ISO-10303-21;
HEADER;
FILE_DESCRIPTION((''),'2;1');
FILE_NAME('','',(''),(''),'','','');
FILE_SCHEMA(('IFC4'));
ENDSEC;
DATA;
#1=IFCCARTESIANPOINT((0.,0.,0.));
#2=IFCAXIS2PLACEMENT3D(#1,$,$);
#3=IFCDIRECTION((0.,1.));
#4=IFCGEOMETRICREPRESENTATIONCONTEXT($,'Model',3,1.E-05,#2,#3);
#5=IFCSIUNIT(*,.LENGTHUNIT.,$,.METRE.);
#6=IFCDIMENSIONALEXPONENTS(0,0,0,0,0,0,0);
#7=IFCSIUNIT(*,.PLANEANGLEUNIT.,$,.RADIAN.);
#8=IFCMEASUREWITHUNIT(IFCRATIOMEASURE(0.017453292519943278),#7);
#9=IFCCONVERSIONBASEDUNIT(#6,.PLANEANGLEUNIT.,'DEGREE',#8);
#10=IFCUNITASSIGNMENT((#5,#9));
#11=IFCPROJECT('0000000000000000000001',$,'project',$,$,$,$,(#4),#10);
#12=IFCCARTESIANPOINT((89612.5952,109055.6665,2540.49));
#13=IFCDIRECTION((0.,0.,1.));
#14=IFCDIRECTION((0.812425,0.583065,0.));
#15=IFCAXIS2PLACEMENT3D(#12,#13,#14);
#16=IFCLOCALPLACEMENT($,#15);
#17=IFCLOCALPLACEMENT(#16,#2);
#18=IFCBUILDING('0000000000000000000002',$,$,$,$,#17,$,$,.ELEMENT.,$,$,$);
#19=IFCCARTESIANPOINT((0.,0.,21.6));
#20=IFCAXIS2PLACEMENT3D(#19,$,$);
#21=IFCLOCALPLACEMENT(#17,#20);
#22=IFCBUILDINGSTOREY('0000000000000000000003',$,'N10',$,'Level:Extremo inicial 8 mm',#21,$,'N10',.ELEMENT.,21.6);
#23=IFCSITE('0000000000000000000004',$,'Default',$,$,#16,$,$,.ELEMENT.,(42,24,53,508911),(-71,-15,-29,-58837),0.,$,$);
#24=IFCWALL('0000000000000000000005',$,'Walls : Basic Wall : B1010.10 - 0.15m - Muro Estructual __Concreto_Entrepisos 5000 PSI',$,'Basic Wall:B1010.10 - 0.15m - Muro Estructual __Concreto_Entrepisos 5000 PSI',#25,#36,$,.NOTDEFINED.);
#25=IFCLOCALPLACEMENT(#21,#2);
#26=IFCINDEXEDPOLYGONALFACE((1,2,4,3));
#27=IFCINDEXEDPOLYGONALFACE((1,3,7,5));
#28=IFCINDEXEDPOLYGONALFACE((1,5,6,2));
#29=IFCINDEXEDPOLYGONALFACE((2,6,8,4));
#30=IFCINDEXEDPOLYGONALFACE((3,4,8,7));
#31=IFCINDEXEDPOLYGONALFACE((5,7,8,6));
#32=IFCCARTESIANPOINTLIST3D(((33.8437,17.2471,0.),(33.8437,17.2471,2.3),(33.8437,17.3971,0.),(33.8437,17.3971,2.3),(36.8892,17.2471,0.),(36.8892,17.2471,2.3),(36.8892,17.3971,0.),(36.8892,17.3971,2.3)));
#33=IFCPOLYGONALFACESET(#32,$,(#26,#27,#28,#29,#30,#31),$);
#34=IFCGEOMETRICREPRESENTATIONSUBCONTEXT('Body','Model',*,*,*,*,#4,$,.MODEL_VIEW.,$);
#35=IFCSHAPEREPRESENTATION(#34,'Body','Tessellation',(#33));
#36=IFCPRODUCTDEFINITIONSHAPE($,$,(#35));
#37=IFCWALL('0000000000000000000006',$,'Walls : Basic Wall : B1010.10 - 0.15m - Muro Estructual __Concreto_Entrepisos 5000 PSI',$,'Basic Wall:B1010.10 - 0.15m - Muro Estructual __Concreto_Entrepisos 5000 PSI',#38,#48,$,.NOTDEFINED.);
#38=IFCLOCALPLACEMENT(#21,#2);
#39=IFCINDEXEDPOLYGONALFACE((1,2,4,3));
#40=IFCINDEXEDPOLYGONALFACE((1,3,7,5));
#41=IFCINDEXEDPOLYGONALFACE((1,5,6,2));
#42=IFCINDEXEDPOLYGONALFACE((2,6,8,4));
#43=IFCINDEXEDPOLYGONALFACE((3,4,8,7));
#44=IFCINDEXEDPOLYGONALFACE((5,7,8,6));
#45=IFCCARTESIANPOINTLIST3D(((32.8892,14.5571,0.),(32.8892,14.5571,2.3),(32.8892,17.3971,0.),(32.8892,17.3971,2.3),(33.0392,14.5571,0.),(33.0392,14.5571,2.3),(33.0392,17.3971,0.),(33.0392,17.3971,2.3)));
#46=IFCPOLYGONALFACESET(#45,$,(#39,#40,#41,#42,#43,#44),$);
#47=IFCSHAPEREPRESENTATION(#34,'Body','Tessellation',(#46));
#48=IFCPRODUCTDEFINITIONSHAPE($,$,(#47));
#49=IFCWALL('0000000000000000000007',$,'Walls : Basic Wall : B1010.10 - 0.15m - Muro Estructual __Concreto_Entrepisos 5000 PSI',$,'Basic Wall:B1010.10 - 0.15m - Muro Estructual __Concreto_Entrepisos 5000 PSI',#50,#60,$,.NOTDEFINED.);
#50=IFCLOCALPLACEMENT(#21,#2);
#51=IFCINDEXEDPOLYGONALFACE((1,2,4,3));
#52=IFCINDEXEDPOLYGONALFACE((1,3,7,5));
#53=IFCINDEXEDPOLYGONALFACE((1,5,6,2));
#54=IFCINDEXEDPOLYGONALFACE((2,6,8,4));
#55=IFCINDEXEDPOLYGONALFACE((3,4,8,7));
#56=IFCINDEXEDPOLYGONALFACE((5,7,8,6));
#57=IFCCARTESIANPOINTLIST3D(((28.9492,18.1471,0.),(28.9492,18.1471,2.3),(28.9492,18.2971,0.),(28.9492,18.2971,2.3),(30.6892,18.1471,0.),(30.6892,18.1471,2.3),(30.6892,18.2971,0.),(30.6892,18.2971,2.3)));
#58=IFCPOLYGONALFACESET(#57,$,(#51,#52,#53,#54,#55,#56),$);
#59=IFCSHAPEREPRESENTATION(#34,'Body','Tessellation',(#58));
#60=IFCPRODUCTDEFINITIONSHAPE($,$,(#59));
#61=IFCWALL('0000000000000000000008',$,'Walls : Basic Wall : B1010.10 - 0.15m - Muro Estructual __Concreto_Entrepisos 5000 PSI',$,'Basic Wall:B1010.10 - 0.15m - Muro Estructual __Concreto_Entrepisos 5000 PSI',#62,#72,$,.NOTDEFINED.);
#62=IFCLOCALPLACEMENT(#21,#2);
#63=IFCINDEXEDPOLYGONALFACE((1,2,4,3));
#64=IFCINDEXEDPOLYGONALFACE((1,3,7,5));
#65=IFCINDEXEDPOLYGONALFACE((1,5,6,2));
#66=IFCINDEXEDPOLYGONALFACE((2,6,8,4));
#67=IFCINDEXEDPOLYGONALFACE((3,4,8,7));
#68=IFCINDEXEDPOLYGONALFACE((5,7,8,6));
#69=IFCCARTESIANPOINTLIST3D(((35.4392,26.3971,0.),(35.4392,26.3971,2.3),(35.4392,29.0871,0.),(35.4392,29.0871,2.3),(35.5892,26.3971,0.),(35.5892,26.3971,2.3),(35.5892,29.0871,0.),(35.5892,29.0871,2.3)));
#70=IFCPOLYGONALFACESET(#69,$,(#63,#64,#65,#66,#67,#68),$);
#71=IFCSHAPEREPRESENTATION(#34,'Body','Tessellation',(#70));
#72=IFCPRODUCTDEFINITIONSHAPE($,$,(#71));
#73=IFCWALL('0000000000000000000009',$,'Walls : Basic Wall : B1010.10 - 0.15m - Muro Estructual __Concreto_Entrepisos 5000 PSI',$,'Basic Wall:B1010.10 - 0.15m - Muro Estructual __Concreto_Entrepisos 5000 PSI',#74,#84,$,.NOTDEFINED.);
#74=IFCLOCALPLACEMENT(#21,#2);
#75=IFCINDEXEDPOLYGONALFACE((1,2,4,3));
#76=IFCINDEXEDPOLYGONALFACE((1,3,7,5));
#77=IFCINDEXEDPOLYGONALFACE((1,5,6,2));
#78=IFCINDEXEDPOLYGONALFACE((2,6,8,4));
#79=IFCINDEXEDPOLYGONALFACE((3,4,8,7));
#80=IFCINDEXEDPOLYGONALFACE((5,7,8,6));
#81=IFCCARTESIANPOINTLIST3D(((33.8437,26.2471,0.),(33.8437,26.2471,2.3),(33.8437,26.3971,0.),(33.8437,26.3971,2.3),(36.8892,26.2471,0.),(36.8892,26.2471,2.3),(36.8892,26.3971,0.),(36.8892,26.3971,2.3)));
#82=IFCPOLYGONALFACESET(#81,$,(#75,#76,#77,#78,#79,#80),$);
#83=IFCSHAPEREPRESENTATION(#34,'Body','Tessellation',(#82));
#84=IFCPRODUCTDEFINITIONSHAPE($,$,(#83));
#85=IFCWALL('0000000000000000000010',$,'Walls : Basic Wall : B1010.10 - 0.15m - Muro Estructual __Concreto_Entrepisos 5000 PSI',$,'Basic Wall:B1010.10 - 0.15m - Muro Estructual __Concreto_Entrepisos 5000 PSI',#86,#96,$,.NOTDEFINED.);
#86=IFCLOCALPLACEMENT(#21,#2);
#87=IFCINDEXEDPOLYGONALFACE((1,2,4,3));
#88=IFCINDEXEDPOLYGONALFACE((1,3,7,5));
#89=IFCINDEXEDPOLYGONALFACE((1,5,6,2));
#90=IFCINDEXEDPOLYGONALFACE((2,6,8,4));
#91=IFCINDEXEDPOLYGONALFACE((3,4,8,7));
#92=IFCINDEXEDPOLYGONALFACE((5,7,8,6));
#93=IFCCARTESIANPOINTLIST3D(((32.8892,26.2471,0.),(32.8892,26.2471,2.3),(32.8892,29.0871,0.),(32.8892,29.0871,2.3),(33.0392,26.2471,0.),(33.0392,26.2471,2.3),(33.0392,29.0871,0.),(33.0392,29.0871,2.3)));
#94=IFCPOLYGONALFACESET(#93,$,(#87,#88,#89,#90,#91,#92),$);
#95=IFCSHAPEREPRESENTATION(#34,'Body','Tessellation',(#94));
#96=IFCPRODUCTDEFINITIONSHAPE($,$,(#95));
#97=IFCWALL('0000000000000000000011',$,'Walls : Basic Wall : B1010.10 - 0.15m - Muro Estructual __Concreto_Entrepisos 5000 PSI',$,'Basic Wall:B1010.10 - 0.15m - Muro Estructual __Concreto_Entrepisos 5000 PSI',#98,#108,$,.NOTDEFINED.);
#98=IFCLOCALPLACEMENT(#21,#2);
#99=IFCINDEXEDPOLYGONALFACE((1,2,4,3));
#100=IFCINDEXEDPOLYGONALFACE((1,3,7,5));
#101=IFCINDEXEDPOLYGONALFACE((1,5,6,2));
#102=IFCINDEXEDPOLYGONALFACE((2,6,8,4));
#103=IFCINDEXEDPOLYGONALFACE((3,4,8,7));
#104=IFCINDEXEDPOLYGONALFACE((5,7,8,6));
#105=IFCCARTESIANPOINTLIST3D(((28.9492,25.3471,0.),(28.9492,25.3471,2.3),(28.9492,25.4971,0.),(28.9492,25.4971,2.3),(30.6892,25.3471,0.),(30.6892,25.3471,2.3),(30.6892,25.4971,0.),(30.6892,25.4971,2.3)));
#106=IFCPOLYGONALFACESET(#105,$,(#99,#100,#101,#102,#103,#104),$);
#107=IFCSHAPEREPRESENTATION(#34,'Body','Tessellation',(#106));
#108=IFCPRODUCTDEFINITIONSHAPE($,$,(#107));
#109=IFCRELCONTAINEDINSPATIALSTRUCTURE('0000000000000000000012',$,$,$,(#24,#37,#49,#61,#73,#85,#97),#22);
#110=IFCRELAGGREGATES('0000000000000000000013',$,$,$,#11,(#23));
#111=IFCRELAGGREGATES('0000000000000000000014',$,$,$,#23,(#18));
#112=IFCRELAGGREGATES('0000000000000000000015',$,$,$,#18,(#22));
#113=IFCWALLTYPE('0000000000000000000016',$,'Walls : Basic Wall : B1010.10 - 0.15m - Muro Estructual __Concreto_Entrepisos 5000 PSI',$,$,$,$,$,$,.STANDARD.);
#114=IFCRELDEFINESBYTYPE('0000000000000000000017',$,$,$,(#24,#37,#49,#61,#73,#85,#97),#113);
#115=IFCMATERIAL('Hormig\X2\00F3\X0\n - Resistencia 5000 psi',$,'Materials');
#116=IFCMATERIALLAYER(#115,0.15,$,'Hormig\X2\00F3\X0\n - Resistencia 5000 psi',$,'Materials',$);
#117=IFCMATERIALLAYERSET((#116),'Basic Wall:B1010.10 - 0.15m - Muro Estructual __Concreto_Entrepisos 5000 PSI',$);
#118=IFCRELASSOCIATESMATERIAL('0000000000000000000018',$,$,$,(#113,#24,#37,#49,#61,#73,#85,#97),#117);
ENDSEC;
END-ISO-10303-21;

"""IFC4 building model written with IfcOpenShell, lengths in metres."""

from ifc_helpers import new_model, entity, si_unit, converted_unit, direction, frame, frame_2d, origin, place, context, subcontext, project, spatial, rectangle, extrude, material, layer, layer_set, layer_usage, type_object, element, save


model = new_model("IFC4")

# Units and contexts
model_context = context("Model", 3, precision=1e-05, world=origin(), true_north=direction((0.0, 1.0)))
body_context = subcontext(model_context, "Body", "Model", "MODEL_VIEW")
ifc_project = project(units=[si_unit("LENGTHUNIT", "METRE"), converted_unit("PLANEANGLEUNIT", "DEGREE", entity("IfcRatioMeasure", 0.017453292519943278), si_unit("PLANEANGLEUNIT", "RADIAN"), dimensions=[0, 0, 0, 0, 0, 0, 0])], contexts=[model_context])

# Site, building, storey
site_placement = place(None, frame((89612.5952, 109055.6665, 2540.49), z_axis=(0.0, 0.0, 1.0), x_axis=(0.812425, 0.583065, 0.0)))
site = spatial("IfcSite", under=ifc_project, at=site_placement, Name="Default", CompositionType="ELEMENT", RefLatitude=(42, 24, 53, 508911), RefLongitude=(-71, -15, -29, -58837), RefElevation=0.0)
building_placement = place(site_placement, origin())
building = spatial("IfcBuilding", under=site, at=building_placement, CompositionType="ELEMENT")
storey_placement = place(building_placement, frame((0.0, 0.0, 21.6)))
storey = spatial("IfcBuildingStorey", under=building, at=storey_placement, Name="N10", ObjectType="Level:Extremo inicial 8 mm", LongName="N10", CompositionType="ELEMENT", Elevation=21.6)

# Walls
ifc_material = material(Name="Hormigón - Resistencia 5000 psi", Category="Materials")
ifc_layer_1 = layer(ifc_material, 0.15, Name="Hormigón - Resistencia 5000 psi", Category="Materials")
ifc_layer_set_1 = layer_set([ifc_layer_1], Name="Basic Wall:B1010.10 - 0.15m - Muro Estructual __Concreto_Entrepisos 5000 PSI")
wall_type_1 = type_object("IfcWallType", Name="Walls : Basic Wall : B1010.10 - 0.15m - Muro Estructual __Concreto_Entrepisos 5000 PSI", PredefinedType="STANDARD", material=ifc_layer_set_1)
ifc_layer_usage_1 = layer_usage(ifc_layer_set_1, "AXIS2", "NEGATIVE", 0.075)
wall_1_placement = place(storey_placement, frame((36.8892, 17.3221, 0.0), z_axis=(0.0, 0.0, 1.0), x_axis=(-1.0, 0.0, 0.0)))
element("IfcWall", 1, at=wall_1_placement, inside=storey, type_object=wall_type_1, material=ifc_layer_usage_1, Name="Walls : Basic Wall : B1010.10 - 0.15m - Muro Estructual __Concreto_Entrepisos 5000 PSI", ObjectType="Basic Wall:B1010.10 - 0.15m - Muro Estructual __Concreto_Entrepisos 5000 PSI", PredefinedType="NOTDEFINED", context=body_context, shape_type="SweptSolid", body=[
    extrude(rectangle(XDim=3.0455, YDim=0.15, at=frame_2d((1.5228, 0.0), x_axis=(-1.0, 0.0))), origin(), (0.0, 0.0, 1.0), 2.3),
])
ifc_layer_usage_2 = layer_usage(ifc_layer_set_1, "AXIS2", "NEGATIVE", 0.075)
wall_2_placement = place(storey_placement, frame((32.9642, 14.5571, 0.0), z_axis=(0.0, 0.0, 1.0), x_axis=(0.0, 1.0, 0.0)))
element("IfcWall", 2, at=wall_2_placement, inside=storey, type_object=wall_type_1, material=ifc_layer_usage_2, Name="Walls : Basic Wall : B1010.10 - 0.15m - Muro Estructual __Concreto_Entrepisos 5000 PSI", ObjectType="Basic Wall:B1010.10 - 0.15m - Muro Estructual __Concreto_Entrepisos 5000 PSI", PredefinedType="NOTDEFINED", context=body_context, shape_type="SweptSolid", body=[
    extrude(rectangle(XDim=2.84, YDim=0.15, at=frame_2d((1.42, 0.0), x_axis=(-1.0, 0.0))), origin(), (0.0, 0.0, 1.0), 2.3),
])
ifc_layer_usage_3 = layer_usage(ifc_layer_set_1, "AXIS2", "NEGATIVE", 0.075)
wall_3_placement = place(storey_placement, frame((30.6892, 18.2221, 0.0), z_axis=(0.0, 0.0, 1.0), x_axis=(-1.0, 0.0, 0.0)))
element("IfcWall", 3, at=wall_3_placement, inside=storey, type_object=wall_type_1, material=ifc_layer_usage_3, Name="Walls : Basic Wall : B1010.10 - 0.15m - Muro Estructual __Concreto_Entrepisos 5000 PSI", ObjectType="Basic Wall:B1010.10 - 0.15m - Muro Estructual __Concreto_Entrepisos 5000 PSI", PredefinedType="NOTDEFINED", context=body_context, shape_type="SweptSolid", body=[
    extrude(rectangle(XDim=1.74, YDim=0.15, at=frame_2d((0.87, 0.0), x_axis=(-1.0, 0.0))), origin(), (0.0, 0.0, 1.0), 2.3),
])
ifc_layer_usage_4 = layer_usage(ifc_layer_set_1, "AXIS2", "POSITIVE", -0.075)
wall_4_placement = place(storey_placement, frame((35.5142, 29.0871, 0.0), z_axis=(0.0, 0.0, 1.0), x_axis=(0.0, -1.0, 0.0)))
element("IfcWall", 4, at=wall_4_placement, inside=storey, type_object=wall_type_1, material=ifc_layer_usage_4, Name="Walls : Basic Wall : B1010.10 - 0.15m - Muro Estructual __Concreto_Entrepisos 5000 PSI", ObjectType="Basic Wall:B1010.10 - 0.15m - Muro Estructual __Concreto_Entrepisos 5000 PSI", PredefinedType="NOTDEFINED", context=body_context, shape_type="SweptSolid", body=[
    extrude(rectangle(XDim=2.69, YDim=0.15, at=frame_2d((1.345, 0.0), x_axis=(-1.0, 0.0))), origin(), (0.0, 0.0, 1.0), 2.3),
])
ifc_layer_usage_5 = layer_usage(ifc_layer_set_1, "AXIS2", "POSITIVE", -0.075)
wall_5_placement = place(storey_placement, frame((36.8892, 26.3221, 0.0), z_axis=(0.0, 0.0, 1.0), x_axis=(-1.0, 0.0, 0.0)))
element("IfcWall", 5, at=wall_5_placement, inside=storey, type_object=wall_type_1, material=ifc_layer_usage_5, Name="Walls : Basic Wall : B1010.10 - 0.15m - Muro Estructual __Concreto_Entrepisos 5000 PSI", ObjectType="Basic Wall:B1010.10 - 0.15m - Muro Estructual __Concreto_Entrepisos 5000 PSI", PredefinedType="NOTDEFINED", context=body_context, shape_type="SweptSolid", body=[
    extrude(rectangle(XDim=3.0455, YDim=0.15, at=frame_2d((1.5228, 0.0), x_axis=(-1.0, 0.0))), origin(), (0.0, 0.0, 1.0), 2.3),
])
ifc_layer_usage_6 = layer_usage(ifc_layer_set_1, "AXIS2", "POSITIVE", -0.075)
wall_6_placement = place(storey_placement, frame((32.9642, 29.0871, 0.0), z_axis=(0.0, 0.0, 1.0), x_axis=(0.0, -1.0, 0.0)))
element("IfcWall", 6, at=wall_6_placement, inside=storey, type_object=wall_type_1, material=ifc_layer_usage_6, Name="Walls : Basic Wall : B1010.10 - 0.15m - Muro Estructual __Concreto_Entrepisos 5000 PSI", ObjectType="Basic Wall:B1010.10 - 0.15m - Muro Estructual __Concreto_Entrepisos 5000 PSI", PredefinedType="NOTDEFINED", context=body_context, shape_type="SweptSolid", body=[
    extrude(rectangle(XDim=2.84, YDim=0.15, at=frame_2d((1.42, 0.0), x_axis=(-1.0, 0.0))), origin(), (0.0, 0.0, 1.0), 2.3),
])
ifc_layer_usage_7 = layer_usage(ifc_layer_set_1, "AXIS2", "POSITIVE", -0.075)
wall_7_placement = place(storey_placement, frame((30.6892, 25.4221, 0.0), z_axis=(0.0, 0.0, 1.0), x_axis=(-1.0, 0.0, 0.0)))
element("IfcWall", 7, at=wall_7_placement, inside=storey, type_object=wall_type_1, material=ifc_layer_usage_7, Name="Walls : Basic Wall : B1010.10 - 0.15m - Muro Estructual __Concreto_Entrepisos 5000 PSI", ObjectType="Basic Wall:B1010.10 - 0.15m - Muro Estructual __Concreto_Entrepisos 5000 PSI", PredefinedType="NOTDEFINED", context=body_context, shape_type="SweptSolid", body=[
    extrude(rectangle(XDim=1.74, YDim=0.15, at=frame_2d((0.87, 0.0), x_axis=(-1.0, 0.0))), origin(), (0.0, 0.0, 1.0), 2.3),
])

save(model, "model.ifc")
